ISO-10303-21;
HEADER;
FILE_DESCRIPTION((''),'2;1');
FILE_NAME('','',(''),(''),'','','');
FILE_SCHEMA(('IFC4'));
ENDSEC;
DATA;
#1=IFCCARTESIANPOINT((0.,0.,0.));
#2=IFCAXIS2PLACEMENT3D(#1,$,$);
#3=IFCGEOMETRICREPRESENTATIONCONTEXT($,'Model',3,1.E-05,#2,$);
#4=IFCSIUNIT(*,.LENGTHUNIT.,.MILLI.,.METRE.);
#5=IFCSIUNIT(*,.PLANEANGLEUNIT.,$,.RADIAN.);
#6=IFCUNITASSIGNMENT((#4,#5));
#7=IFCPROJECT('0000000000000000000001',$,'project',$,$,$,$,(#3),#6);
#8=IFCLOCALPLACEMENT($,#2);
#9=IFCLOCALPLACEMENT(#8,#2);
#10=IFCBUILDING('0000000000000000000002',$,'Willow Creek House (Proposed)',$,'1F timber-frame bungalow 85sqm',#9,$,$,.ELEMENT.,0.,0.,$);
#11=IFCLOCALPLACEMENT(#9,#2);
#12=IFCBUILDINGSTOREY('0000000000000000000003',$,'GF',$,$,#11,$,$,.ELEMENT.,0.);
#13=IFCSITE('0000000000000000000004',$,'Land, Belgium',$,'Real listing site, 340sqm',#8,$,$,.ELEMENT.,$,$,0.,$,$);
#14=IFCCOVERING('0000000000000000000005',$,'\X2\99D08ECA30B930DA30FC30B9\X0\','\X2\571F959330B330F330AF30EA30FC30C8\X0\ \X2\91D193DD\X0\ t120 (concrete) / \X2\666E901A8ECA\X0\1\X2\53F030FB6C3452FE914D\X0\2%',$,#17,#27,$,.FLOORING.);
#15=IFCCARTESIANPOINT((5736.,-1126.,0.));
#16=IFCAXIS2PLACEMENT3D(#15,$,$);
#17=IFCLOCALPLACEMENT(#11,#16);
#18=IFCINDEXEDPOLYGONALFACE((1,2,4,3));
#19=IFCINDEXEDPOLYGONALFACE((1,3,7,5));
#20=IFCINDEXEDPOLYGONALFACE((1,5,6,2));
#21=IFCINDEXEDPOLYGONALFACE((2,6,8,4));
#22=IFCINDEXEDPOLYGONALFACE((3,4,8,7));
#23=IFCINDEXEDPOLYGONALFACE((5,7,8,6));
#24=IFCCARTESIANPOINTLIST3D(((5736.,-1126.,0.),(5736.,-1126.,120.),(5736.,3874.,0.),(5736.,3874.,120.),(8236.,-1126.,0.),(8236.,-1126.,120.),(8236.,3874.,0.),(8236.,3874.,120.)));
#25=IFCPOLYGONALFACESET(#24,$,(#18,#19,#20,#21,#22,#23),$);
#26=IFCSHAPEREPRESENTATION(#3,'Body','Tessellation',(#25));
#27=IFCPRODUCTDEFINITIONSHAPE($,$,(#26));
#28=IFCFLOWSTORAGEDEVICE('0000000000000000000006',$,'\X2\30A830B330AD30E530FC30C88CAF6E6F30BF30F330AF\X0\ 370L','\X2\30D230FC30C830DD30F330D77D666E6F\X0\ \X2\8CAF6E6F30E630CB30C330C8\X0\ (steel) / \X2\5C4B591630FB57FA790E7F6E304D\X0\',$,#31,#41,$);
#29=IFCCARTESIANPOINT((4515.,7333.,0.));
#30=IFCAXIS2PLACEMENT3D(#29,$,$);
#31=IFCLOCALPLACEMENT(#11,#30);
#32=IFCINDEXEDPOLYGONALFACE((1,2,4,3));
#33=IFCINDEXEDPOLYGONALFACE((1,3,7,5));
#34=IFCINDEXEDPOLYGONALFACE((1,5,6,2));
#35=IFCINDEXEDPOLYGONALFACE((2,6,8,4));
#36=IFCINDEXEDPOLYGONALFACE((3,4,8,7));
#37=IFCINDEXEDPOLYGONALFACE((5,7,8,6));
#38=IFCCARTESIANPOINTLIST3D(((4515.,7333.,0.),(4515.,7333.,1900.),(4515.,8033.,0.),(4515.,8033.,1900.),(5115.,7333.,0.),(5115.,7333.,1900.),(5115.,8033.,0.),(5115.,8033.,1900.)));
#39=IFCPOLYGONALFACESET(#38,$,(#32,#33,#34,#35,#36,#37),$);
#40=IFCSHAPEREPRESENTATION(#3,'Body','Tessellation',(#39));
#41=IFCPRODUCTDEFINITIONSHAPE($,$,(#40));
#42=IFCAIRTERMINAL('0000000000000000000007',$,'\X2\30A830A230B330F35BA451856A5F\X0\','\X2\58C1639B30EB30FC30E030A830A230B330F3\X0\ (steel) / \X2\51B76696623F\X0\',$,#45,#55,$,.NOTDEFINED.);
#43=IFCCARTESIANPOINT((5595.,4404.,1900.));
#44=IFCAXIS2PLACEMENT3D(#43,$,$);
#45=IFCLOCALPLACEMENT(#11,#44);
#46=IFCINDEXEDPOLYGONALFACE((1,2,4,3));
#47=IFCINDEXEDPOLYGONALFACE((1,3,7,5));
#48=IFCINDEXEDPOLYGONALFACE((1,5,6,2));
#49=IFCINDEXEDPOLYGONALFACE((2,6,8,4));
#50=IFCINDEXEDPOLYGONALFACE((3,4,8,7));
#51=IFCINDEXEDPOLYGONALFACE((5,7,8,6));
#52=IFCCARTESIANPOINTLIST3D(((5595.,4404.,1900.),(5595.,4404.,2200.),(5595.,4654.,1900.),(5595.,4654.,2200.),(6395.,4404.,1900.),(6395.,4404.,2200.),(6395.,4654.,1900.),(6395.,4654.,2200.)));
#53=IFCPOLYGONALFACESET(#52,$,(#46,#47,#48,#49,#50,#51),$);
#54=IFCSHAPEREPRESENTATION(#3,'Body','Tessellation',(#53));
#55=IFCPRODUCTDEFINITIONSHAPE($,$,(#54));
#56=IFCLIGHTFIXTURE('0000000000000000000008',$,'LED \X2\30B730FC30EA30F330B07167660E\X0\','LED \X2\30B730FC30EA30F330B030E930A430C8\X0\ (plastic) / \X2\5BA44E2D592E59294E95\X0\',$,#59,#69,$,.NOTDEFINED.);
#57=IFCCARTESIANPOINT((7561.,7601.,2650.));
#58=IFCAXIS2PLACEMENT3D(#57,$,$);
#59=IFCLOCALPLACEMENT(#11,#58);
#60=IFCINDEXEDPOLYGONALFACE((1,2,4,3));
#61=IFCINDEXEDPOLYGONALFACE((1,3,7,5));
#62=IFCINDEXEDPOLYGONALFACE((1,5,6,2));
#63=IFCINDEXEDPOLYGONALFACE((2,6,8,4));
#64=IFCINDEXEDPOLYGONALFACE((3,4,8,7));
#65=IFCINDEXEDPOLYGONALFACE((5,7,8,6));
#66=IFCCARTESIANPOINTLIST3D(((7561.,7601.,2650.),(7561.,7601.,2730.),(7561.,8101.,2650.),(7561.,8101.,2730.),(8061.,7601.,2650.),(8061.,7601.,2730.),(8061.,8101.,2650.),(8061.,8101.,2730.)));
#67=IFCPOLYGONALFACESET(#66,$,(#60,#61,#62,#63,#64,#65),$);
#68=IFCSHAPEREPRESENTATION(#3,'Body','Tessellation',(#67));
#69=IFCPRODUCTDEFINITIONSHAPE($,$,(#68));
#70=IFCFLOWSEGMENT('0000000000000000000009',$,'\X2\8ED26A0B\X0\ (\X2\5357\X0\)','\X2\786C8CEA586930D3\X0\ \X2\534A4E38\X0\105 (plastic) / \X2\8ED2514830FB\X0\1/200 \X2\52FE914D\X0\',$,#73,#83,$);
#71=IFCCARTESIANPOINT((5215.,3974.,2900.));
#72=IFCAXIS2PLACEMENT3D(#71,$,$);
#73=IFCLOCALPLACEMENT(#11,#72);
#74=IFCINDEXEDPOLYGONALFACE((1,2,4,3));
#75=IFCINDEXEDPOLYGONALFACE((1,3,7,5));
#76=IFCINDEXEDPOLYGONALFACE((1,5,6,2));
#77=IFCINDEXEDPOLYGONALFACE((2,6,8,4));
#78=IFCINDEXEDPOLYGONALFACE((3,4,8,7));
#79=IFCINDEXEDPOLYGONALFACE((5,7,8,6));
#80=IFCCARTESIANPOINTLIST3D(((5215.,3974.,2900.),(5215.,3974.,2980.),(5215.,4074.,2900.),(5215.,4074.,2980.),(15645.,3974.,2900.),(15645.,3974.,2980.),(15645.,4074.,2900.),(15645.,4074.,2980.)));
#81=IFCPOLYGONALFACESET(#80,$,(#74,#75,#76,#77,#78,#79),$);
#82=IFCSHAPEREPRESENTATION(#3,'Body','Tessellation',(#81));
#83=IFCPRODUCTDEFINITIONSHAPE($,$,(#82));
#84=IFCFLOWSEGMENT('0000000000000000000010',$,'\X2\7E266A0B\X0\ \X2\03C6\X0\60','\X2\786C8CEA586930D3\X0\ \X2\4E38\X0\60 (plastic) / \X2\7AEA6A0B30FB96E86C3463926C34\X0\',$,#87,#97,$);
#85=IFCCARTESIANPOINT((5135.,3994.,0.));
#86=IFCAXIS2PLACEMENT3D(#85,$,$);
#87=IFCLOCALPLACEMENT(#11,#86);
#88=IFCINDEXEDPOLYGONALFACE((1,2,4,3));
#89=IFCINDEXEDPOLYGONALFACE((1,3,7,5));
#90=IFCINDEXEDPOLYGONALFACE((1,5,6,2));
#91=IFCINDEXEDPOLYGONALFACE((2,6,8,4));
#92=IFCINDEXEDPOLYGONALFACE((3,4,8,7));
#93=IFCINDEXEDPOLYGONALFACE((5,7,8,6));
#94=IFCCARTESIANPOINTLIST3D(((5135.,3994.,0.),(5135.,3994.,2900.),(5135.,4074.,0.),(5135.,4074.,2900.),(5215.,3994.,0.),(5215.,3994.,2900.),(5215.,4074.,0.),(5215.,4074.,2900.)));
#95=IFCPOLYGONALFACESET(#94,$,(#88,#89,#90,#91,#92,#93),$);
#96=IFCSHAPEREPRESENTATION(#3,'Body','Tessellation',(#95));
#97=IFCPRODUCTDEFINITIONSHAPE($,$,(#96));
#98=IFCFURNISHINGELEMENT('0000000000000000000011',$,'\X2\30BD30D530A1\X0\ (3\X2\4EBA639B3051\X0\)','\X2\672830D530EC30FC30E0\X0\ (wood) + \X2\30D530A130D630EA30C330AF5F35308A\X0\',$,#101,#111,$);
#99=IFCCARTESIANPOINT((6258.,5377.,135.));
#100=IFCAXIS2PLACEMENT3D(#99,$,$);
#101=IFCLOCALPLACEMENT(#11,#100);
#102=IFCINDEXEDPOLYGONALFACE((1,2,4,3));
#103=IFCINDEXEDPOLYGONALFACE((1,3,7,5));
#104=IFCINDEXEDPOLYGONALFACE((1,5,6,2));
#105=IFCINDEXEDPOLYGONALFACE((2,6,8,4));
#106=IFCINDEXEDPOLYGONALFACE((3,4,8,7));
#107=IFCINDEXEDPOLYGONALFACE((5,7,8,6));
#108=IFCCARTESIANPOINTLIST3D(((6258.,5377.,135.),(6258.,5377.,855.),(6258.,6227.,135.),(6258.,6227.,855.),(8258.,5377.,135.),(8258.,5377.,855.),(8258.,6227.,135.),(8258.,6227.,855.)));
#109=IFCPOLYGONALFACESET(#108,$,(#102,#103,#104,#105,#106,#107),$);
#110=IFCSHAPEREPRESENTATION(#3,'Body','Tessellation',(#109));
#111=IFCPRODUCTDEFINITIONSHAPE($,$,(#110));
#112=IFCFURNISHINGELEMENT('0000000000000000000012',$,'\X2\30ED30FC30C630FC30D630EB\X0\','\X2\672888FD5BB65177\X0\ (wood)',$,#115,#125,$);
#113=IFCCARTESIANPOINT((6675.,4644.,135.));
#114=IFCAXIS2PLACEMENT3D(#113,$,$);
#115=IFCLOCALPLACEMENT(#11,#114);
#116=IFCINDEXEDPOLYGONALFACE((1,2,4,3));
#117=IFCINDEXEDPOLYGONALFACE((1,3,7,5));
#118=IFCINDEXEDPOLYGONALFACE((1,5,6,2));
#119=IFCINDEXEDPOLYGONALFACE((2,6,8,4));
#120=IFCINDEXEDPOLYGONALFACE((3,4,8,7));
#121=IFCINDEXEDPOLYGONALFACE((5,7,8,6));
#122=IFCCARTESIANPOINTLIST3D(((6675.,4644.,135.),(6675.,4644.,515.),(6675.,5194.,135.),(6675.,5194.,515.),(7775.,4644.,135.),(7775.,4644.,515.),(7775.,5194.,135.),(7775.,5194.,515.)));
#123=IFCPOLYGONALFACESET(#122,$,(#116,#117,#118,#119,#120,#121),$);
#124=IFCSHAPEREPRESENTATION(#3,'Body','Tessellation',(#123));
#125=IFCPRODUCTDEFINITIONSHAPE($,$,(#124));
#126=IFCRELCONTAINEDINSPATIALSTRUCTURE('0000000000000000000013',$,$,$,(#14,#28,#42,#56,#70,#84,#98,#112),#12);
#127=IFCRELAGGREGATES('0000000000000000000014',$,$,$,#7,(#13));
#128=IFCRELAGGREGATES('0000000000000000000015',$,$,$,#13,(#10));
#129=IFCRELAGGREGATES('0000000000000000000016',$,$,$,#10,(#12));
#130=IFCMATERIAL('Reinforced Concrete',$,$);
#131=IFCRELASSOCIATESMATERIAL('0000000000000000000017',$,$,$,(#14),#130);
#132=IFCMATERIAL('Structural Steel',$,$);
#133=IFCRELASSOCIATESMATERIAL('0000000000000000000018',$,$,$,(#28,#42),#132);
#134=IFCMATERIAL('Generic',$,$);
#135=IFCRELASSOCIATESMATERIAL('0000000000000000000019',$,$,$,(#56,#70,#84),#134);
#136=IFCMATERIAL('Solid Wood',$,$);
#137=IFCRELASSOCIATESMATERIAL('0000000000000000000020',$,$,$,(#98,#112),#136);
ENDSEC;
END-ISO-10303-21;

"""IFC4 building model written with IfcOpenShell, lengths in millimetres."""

from ifc_helpers import new_model, si_unit, frame, frame_2d, origin, place, context, project, spatial, rectangle, extrude, material, element, save


model = new_model("IFC4")

# Units and contexts
model_context = context("Model", 3, precision=1e-05, world=origin())
ifc_project = project(units=[si_unit("LENGTHUNIT", "METRE", prefix="MILLI"), si_unit("PLANEANGLEUNIT", "RADIAN")], contexts=[model_context])

# Site, building, storey
site_placement = place(None, origin())
site = spatial("IfcSite", under=ifc_project, at=site_placement, Name="Land, Belgium", ObjectType="Real listing site, 340sqm", CompositionType="ELEMENT", RefElevation=0.0)
building_placement = place(site_placement, origin())
building = spatial("IfcBuilding", under=site, at=building_placement, Name="Willow Creek House (Proposed)", ObjectType="1F timber-frame bungalow 85sqm", CompositionType="ELEMENT", ElevationOfRefHeight=0.0, ElevationOfTerrain=0.0)
storey_placement = place(building_placement, origin())
storey = spatial("IfcBuildingStorey", under=building, at=storey_placement, Name="GF", CompositionType="ELEMENT", Elevation=0.0)

# Shared definitions
ifc_material_1 = material(Name="Solid Wood")

# Shared definitions
ifc_material_2 = material(Name="Reinforced Concrete")

# Shared definitions
ifc_material_3 = material(Name="Structural Steel")

# Covering
ifc_material_4 = material(Name="Generic")
covering_1_placement = place(storey_placement, frame((5736.0, -1126.0, 0.0)))
element("IfcCovering", 1, at=covering_1_placement, inside=storey, material=ifc_material_2, Name="駐車スペース", Description="土間コンクリート 金鏝 t120 (concrete) / 普通車1台・水勾配2%", PredefinedType="FLOORING", context=model_context, shape_type="SweptSolid", body=[
    extrude(rectangle(XDim=2500.0, YDim=5000.0, at=frame_2d((1250.0, 2500.0))), frame((5736.0, -1126.0, 0.0)), (0.0, 0.0, 1.0), 120.0),
])

# Flow storage device
flow_storage_device_placement = place(storey_placement, frame((4515.0, 7333.0, 0.0)))
element("IfcFlowStorageDevice", 2, at=flow_storage_device_placement, inside=storey, material=ifc_material_3, Name="エコキュート貯湯タンク 370L", Description="ヒートポンプ給湯 貯湯ユニット (steel) / 屋外・基礎置き", context=model_context, shape_type="SweptSolid", body=[
    extrude(rectangle(XDim=600.0, YDim=700.0, at=frame_2d((300.0, 350.0))), frame((4515.0, 7333.0, 0.0)), (0.0, 0.0, 1.0), 1900.0),
])

# Air terminal
air_terminal_placement = place(storey_placement, frame((5595.0, 4404.0, 1900.0)))
element("IfcAirTerminal", 3, at=air_terminal_placement, inside=storey, material=ifc_material_3, Name="エアコン室内機", Description="壁掛ルームエアコン (steel) / 冷暖房", PredefinedType="NOTDEFINED", context=model_context, shape_type="SweptSolid", body=[
    extrude(rectangle(XDim=800.0, YDim=250.0, at=frame_2d((400.0, 125.0))), frame((5595.0, 4404.0, 1900.0)), (0.0, 0.0, 1.0), 300.0),
])

# Light fixture
light_fixture_placement = place(storey_placement, frame((7561.0, 7601.0, 2650.0)))
element("IfcLightFixture", 4, at=light_fixture_placement, inside=storey, material=ifc_material_4, Name="LED シーリング照明", Description="LED シーリングライト (plastic) / 室中央天井", PredefinedType="NOTDEFINED", context=model_context, shape_type="SweptSolid", body=[
    extrude(rectangle(XDim=500.0, YDim=500.0, at=frame_2d((250.0, 250.0))), frame((7561.0, 7601.0, 2650.0)), (0.0, 0.0, 1.0), 80.0),
])

# Flow segments
flow_segment_1_placement = place(storey_placement, frame((5215.0, 3974.0, 2900.0)))
element("IfcFlowSegment", 5, at=flow_segment_1_placement, inside=storey, material=ifc_material_4, Name="軒樋 (南)", Description="硬質塩ビ 半丸105 (plastic) / 軒先・1/200 勾配", context=model_context, shape_type="SweptSolid", body=[
    extrude(rectangle(XDim=10430.0, YDim=100.0, at=frame_2d((5215.0, 50.0))), frame((5215.0, 3974.0, 2900.0)), (0.0, 0.0, 1.0), 80.0),
])
flow_segment_2_placement = place(storey_placement, frame((5135.0, 3994.0, 0.0)))
element("IfcFlowSegment", 6, at=flow_segment_2_placement, inside=storey, material=ifc_material_4, Name="縦樋 φ60", Description="硬質塩ビ 丸60 (plastic) / 竪樋・雨水排水", context=model_context, shape_type="SweptSolid", body=[
    extrude(rectangle(XDim=80.0, YDim=80.0, at=frame_2d((40.0, 40.0))), frame((5135.0, 3994.0, 0.0)), (0.0, 0.0, 1.0), 2900.0),
])

# Furnishing elements
furnishing_1_placement = place(storey_placement, frame((6258.0, 5377.0, 135.0)))
element("IfcFurnishingElement", 7, at=furnishing_1_placement, inside=storey, material=ifc_material_1, Name="ソファ (3人掛け)", Description="木フレーム (wood) + ファブリック張り", context=model_context, shape_type="SweptSolid", body=[
    extrude(rectangle(XDim=2000.0, YDim=850.0, at=frame_2d((1000.0, 425.0))), frame((6258.0, 5377.0, 135.0)), (0.0, 0.0, 1.0), 720.0),
])
furnishing_2_placement = place(storey_placement, frame((6675.0, 4644.0, 135.0)))
element("IfcFurnishingElement", 8, at=furnishing_2_placement, inside=storey, material=ifc_material_1, Name="ローテーブル", Description="木製家具 (wood)", context=model_context, shape_type="SweptSolid", body=[
    extrude(rectangle(XDim=1100.0, YDim=550.0, at=frame_2d((550.0, 275.0))), frame((6675.0, 4644.0, 135.0)), (0.0, 0.0, 1.0), 380.0),
])

save(model, "model.ifc")
